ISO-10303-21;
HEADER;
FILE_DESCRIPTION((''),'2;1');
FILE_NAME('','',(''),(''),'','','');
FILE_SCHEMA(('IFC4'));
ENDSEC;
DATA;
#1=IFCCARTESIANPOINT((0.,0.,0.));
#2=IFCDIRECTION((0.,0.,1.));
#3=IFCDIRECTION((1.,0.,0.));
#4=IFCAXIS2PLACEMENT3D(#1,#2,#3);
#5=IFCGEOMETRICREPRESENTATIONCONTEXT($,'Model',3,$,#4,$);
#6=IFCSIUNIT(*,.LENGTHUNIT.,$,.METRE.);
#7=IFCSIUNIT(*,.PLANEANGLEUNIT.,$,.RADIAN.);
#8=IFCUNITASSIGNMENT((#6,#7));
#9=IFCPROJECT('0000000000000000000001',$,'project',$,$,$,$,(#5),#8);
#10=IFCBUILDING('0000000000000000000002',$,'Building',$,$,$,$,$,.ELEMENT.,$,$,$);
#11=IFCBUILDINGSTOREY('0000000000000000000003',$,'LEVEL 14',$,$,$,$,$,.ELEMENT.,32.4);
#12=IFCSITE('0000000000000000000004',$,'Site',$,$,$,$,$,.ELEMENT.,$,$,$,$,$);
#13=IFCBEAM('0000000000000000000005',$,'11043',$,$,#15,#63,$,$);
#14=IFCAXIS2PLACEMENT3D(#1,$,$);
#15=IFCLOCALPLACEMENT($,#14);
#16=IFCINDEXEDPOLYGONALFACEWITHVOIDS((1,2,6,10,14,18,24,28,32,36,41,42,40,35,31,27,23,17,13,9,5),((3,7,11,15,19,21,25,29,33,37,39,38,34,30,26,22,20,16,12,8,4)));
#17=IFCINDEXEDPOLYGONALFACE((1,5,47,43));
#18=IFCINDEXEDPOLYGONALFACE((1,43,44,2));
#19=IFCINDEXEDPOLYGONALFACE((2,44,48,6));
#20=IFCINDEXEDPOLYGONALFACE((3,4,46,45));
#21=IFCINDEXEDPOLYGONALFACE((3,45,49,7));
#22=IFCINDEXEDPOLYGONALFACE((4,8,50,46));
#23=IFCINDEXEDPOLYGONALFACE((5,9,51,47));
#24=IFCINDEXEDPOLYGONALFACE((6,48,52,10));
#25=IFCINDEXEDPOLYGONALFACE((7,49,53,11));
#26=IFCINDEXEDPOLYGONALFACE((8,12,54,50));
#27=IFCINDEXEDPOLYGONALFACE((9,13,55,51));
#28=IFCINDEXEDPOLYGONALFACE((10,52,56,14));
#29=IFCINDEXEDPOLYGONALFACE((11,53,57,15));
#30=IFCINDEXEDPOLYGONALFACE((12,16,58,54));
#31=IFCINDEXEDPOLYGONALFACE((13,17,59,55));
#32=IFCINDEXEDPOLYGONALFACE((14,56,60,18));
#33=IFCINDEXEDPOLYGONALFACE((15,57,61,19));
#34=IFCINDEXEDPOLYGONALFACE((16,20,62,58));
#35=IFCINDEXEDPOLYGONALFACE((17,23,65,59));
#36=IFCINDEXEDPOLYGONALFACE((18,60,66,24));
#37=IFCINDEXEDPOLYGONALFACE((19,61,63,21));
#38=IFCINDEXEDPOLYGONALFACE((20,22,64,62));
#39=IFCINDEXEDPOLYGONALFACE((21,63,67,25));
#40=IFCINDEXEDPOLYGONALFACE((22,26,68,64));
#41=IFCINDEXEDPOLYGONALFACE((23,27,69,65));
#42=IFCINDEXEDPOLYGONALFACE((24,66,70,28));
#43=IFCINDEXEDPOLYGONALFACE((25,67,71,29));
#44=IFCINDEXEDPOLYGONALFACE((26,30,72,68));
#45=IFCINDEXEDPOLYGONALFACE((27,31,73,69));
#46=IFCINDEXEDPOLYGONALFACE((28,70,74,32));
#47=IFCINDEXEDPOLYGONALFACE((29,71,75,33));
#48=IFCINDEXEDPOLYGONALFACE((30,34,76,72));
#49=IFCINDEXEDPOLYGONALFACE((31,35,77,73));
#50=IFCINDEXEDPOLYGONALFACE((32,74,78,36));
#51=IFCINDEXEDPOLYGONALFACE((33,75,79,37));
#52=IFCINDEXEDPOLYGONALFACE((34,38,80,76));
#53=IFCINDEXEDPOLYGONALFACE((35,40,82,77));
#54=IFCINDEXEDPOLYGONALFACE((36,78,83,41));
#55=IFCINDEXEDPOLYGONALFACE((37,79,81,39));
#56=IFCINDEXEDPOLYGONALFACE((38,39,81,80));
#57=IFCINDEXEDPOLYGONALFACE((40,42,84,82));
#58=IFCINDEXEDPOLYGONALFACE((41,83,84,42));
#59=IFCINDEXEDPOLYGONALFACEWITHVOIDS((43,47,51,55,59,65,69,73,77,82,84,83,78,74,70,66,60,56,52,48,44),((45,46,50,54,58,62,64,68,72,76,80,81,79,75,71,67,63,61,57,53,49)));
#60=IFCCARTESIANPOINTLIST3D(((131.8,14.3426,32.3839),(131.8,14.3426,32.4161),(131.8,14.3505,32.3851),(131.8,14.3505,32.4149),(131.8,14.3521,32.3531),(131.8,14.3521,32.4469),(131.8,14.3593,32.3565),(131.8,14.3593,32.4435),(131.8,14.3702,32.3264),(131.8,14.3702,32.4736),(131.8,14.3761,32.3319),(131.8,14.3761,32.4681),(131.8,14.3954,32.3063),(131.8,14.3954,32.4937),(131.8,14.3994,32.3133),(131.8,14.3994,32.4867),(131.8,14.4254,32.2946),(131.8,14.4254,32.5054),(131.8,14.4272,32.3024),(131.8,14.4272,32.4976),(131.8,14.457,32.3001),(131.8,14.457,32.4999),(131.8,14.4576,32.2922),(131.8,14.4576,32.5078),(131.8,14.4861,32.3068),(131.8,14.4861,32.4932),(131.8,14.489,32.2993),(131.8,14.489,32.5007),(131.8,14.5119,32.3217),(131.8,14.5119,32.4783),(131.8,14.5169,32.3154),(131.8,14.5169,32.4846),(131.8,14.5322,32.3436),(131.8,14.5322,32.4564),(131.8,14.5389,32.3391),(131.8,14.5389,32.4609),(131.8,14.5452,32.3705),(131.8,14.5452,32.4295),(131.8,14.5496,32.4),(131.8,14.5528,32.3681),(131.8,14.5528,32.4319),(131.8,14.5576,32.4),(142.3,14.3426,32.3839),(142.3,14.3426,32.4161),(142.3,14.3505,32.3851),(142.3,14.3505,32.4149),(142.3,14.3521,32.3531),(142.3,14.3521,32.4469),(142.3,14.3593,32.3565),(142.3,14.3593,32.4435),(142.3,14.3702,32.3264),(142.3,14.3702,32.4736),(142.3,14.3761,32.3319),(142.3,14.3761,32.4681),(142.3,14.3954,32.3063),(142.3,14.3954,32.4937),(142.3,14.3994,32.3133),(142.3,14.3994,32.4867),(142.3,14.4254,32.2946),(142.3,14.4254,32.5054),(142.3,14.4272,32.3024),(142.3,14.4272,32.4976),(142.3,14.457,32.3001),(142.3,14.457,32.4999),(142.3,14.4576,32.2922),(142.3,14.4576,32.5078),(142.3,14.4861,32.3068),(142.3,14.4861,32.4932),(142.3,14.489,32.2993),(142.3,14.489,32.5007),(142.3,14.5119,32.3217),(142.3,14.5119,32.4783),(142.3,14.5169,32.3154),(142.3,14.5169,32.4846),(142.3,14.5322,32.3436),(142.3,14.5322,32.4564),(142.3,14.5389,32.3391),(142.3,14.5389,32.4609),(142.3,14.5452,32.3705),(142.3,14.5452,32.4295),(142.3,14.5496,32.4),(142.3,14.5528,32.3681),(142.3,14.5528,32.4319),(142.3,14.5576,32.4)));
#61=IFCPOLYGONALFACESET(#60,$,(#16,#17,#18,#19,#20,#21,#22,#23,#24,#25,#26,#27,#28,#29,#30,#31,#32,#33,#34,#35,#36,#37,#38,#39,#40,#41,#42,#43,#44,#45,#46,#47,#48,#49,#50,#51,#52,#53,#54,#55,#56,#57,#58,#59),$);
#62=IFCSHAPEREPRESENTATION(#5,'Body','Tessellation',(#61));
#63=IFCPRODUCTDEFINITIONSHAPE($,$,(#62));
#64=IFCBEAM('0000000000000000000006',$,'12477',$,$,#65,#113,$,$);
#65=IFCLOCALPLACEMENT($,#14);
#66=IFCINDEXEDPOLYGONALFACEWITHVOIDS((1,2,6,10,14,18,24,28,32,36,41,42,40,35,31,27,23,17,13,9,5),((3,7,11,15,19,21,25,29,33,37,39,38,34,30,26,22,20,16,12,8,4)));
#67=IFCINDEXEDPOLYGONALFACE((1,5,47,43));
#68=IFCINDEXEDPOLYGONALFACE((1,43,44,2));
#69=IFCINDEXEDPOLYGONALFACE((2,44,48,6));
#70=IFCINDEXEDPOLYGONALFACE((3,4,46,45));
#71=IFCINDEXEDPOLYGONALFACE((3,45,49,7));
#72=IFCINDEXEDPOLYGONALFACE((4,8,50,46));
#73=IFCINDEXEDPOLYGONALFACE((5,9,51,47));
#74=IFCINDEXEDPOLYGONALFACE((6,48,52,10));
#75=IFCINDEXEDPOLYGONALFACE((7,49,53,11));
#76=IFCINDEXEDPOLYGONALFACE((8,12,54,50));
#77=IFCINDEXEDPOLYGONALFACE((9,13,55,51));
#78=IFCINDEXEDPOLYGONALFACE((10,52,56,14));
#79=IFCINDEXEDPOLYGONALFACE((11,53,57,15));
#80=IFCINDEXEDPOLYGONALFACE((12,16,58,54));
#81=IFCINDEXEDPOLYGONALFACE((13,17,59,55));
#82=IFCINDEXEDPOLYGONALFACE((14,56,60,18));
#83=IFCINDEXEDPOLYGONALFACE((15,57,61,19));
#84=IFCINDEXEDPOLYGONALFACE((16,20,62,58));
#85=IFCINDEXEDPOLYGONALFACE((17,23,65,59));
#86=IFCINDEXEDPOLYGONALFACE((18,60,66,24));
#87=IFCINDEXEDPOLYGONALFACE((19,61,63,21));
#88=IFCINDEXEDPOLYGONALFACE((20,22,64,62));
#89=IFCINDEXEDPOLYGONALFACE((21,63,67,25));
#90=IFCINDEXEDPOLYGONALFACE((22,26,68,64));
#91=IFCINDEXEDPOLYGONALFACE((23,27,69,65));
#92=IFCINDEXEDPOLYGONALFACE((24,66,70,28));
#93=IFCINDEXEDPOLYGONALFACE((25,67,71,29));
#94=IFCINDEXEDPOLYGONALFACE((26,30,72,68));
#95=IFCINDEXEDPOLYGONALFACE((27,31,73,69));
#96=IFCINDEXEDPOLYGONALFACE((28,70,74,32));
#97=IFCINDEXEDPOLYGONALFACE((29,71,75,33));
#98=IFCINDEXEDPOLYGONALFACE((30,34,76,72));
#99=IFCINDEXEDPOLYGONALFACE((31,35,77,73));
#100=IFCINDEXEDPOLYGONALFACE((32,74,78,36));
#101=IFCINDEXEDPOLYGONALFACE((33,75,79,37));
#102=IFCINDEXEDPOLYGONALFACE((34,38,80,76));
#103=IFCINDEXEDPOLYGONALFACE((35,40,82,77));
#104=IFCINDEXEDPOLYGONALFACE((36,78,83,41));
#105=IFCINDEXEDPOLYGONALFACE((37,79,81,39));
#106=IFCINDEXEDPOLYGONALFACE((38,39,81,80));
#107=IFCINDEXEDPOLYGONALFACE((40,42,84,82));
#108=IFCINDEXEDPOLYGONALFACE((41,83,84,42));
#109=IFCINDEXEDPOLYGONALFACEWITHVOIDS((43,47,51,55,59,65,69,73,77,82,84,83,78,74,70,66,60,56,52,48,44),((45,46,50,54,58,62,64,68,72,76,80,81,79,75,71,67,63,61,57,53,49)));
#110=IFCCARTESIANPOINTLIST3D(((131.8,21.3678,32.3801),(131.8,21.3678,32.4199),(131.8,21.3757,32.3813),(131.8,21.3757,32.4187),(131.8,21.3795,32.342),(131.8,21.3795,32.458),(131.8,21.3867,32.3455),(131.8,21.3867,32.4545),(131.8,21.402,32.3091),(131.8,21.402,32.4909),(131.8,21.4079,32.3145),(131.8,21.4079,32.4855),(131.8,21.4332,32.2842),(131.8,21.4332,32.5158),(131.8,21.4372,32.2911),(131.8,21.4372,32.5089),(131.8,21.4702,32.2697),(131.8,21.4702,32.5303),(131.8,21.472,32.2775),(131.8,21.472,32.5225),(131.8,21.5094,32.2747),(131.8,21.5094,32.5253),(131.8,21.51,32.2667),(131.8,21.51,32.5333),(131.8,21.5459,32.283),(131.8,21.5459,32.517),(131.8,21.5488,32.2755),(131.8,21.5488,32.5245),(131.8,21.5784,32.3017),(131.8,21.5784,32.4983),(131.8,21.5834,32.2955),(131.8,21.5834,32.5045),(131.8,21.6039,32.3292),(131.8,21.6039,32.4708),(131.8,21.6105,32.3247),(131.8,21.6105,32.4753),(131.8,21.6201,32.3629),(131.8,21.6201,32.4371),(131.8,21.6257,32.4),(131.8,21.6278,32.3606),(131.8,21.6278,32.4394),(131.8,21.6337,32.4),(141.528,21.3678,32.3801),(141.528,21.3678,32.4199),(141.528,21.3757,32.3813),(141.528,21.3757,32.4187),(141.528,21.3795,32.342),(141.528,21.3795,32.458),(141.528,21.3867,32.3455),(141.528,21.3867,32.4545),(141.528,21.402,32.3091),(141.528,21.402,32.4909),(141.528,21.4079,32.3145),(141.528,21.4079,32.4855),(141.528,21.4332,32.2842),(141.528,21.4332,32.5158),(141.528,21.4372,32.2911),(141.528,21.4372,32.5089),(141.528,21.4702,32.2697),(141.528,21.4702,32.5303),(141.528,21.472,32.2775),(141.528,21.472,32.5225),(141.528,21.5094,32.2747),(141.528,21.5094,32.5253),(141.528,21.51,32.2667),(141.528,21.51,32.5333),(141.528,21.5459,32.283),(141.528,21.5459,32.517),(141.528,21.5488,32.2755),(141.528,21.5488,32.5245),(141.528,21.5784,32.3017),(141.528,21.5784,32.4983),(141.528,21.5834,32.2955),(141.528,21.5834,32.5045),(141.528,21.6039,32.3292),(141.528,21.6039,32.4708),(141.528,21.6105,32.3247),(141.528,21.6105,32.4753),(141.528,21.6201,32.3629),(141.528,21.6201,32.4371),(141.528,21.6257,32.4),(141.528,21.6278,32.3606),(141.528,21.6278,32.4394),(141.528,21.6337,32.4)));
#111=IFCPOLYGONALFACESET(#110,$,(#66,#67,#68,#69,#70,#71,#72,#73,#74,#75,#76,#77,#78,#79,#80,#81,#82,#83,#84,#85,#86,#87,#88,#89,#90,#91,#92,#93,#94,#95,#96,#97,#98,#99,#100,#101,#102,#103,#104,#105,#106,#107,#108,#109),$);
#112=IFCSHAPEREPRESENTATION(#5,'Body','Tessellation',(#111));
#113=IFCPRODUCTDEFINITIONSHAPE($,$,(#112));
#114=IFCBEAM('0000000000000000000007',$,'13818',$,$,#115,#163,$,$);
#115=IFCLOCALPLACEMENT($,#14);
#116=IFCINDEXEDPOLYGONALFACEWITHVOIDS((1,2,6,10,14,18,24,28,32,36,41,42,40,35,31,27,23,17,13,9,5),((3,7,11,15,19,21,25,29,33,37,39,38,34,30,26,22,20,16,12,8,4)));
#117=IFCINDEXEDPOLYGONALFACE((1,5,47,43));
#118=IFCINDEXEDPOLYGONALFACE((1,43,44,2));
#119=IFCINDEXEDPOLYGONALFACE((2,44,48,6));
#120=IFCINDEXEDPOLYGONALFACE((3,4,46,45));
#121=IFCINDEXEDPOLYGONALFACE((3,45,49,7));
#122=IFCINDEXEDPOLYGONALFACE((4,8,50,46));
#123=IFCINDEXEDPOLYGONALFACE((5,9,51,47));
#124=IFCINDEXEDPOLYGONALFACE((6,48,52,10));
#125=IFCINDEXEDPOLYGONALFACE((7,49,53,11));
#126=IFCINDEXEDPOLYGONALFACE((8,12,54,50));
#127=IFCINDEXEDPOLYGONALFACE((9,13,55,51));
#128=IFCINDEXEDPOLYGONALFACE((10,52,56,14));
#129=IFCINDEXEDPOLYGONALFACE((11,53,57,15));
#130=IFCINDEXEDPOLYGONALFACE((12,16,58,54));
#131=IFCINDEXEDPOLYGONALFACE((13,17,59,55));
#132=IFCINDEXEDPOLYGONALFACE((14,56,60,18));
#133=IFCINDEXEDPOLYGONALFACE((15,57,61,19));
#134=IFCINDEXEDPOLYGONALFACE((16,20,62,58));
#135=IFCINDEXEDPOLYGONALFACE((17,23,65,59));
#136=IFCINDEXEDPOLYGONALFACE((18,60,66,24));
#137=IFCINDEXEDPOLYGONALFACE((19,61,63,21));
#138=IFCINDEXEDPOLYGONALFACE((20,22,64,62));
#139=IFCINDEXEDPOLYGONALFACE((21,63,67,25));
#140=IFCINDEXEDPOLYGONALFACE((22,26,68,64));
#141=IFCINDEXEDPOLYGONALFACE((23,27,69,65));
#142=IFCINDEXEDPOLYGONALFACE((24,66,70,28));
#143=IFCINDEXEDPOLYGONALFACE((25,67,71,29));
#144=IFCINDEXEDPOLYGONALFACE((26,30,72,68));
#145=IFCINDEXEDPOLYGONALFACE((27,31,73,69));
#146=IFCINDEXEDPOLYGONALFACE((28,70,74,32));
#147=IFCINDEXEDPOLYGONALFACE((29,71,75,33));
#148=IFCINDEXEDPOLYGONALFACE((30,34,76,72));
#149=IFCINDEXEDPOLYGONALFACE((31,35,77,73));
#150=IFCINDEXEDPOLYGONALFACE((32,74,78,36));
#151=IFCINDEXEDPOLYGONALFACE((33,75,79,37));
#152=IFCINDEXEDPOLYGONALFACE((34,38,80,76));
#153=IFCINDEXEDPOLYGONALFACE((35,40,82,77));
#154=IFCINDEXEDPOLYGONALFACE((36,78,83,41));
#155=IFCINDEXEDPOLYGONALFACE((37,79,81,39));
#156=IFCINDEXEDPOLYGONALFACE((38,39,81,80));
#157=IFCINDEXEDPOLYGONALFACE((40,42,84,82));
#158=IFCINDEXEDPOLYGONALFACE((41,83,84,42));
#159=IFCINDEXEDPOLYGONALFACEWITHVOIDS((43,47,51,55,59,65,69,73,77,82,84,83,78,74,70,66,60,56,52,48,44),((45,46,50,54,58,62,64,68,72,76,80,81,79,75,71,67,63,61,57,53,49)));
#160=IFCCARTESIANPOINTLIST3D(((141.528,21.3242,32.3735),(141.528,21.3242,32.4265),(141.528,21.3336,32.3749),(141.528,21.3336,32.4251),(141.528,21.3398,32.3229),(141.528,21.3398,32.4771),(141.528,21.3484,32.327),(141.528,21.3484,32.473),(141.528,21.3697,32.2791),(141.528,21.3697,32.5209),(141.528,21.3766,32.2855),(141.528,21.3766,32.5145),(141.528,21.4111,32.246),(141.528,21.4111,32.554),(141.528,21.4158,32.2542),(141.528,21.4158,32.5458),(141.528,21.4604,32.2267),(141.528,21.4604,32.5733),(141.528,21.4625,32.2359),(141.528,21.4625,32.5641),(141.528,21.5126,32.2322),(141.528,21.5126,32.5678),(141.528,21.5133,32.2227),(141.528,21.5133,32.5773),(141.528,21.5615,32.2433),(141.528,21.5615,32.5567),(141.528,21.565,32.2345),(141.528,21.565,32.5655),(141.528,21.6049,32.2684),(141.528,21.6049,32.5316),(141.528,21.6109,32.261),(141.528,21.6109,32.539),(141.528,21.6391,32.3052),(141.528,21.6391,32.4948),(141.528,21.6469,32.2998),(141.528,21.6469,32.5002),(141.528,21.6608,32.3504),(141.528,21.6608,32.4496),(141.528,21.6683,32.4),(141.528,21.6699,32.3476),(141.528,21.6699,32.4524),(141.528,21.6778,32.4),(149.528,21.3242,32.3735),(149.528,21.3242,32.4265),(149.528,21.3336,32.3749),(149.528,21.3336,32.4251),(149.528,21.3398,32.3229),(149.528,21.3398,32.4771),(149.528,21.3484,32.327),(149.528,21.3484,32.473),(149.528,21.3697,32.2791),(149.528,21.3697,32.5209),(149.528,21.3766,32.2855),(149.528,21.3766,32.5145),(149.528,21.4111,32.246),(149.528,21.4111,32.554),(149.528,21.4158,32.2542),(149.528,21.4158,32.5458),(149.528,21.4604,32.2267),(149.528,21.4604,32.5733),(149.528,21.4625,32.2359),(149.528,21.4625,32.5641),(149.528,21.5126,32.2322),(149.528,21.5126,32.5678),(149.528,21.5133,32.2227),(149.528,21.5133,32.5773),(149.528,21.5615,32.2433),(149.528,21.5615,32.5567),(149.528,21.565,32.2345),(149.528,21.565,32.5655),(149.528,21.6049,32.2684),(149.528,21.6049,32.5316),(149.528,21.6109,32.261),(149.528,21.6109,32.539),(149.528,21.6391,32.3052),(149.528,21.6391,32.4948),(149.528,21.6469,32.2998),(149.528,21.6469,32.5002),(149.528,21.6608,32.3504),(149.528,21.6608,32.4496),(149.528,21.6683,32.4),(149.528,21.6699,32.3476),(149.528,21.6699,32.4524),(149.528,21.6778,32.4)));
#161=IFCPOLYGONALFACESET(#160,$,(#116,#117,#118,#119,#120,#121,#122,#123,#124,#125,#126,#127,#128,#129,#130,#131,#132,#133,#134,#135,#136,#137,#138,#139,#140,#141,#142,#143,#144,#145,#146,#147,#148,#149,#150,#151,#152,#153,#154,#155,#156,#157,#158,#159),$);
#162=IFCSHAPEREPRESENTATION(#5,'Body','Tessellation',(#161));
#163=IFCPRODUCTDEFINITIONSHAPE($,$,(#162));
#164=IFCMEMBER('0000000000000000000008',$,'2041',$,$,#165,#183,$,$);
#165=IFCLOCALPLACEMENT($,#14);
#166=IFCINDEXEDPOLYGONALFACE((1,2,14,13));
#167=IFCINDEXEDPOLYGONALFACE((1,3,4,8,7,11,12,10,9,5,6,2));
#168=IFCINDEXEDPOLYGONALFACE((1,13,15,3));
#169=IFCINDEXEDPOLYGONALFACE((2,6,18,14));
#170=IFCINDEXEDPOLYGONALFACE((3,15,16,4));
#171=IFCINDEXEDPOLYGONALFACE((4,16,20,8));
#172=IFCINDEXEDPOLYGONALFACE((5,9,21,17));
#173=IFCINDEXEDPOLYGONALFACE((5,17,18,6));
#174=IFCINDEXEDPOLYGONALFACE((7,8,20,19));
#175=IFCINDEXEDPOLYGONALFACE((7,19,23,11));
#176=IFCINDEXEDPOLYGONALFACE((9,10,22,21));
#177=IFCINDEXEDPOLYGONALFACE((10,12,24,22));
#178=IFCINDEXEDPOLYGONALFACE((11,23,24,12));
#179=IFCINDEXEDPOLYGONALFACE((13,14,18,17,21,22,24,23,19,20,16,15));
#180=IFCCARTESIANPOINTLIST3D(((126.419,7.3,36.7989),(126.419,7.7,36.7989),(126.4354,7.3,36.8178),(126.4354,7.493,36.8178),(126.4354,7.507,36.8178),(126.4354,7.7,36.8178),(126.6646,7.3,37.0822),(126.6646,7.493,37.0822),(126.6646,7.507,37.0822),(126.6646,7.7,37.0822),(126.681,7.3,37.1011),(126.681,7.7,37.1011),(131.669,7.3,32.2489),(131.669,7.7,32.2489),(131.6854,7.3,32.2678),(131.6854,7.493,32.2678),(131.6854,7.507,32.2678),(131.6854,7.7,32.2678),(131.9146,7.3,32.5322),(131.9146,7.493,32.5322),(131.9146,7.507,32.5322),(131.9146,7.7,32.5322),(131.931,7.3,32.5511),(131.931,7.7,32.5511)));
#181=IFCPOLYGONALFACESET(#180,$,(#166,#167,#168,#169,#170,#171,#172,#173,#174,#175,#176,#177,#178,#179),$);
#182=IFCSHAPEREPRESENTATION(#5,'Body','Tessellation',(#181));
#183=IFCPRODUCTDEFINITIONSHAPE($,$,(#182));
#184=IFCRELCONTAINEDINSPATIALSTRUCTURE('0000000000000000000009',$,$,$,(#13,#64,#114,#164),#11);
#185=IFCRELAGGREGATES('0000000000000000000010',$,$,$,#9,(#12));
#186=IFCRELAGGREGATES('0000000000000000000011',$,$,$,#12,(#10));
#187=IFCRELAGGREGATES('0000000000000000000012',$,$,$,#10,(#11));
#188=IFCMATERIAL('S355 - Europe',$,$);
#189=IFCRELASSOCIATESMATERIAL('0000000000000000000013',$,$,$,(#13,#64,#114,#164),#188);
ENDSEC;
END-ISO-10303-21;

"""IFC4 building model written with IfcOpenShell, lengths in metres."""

from ifc_helpers import new_model, si_unit, frame, origin_with_axes, origin_2d_with_axis, place, context, project, spatial, hollow_circle, i_section, extrude, material, material_profile, profile_set, profile_usage, element, save


model = new_model("IFC4")

# Units and contexts
model_context = context("Model", 3, world=origin_with_axes())
ifc_project = project(units=[si_unit("LENGTHUNIT", "METRE"), si_unit("PLANEANGLEUNIT", "RADIAN")], contexts=[model_context])

# Site, building, storey
site = spatial("IfcSite", under=ifc_project, Name="Site", CompositionType="ELEMENT")
building = spatial("IfcBuilding", under=site, Name="Building", CompositionType="ELEMENT")
storey = spatial("IfcBuildingStorey", under=building, Name="LEVEL 14", CompositionType="ELEMENT", Elevation=32.4)

# Shared definitions
ifc_material = material(Name="S355 - Europe")

# Beams
ifc_material_profile_1 = material_profile(ifc_material, hollow_circle(Radius=0.1081, WallThickness=0.008, at=origin_2d_with_axis()))
ifc_profile_set_1 = profile_set([ifc_material_profile_1])
ifc_profile_usage_1 = profile_usage(ifc_profile_set_1, cardinal=10)
beam_1_placement = place(None, frame((131.8, 14.4495, 32.4), z_axis=(1.0, 0.0, 0.0), x_axis=(0.0, 1.0, 0.0)))
element("IfcBeam", 1, at=beam_1_placement, inside=storey, material=ifc_profile_usage_1, Name="11043", context=model_context, shape_type="SweptSolid", body=[
    extrude(hollow_circle(Radius=0.1081, WallThickness=0.008, at=origin_2d_with_axis()), origin_with_axes(), (0.0, 0.0, 1.0), 10.5),
])
ifc_material_profile_2 = material_profile(ifc_material, hollow_circle(Radius=0.1337, WallThickness=0.008, at=origin_2d_with_axis()))
ifc_profile_set_2 = profile_set([ifc_material_profile_2])
ifc_profile_usage_2 = profile_usage(ifc_profile_set_2, cardinal=10)
beam_2_placement = place(None, frame((131.8, 21.5, 32.4), z_axis=(1.0, 0.0, 0.0), x_axis=(0.0, 1.0, 0.0)))
element("IfcBeam", 2, at=beam_2_placement, inside=storey, material=ifc_profile_usage_2, Name="12477", context=model_context, shape_type="SweptSolid", body=[
    extrude(hollow_circle(Radius=0.1337, WallThickness=0.008, at=origin_2d_with_axis()), origin_with_axes(), (0.0, 0.0, 1.0), 9.728),
])
ifc_material_profile_3 = material_profile(ifc_material, hollow_circle(Radius=0.1778, WallThickness=0.0095, at=origin_2d_with_axis()))
ifc_profile_set_3 = profile_set([ifc_material_profile_3])
ifc_profile_usage_3 = profile_usage(ifc_profile_set_3, cardinal=10)
beam_3_placement = place(None, frame((141.528, 21.5, 32.4), z_axis=(1.0, 0.0, 0.0), x_axis=(0.0, 1.0, 0.0)))
element("IfcBeam", 3, at=beam_3_placement, inside=storey, material=ifc_profile_usage_3, Name="13818", context=model_context, shape_type="SweptSolid", body=[
    extrude(hollow_circle(Radius=0.1778, WallThickness=0.0095, at=origin_2d_with_axis()), origin_with_axes(), (0.0, 0.0, 1.0), 8.0),
])

# Member
ifc_material_profile_4 = material_profile(ifc_material, i_section(OverallWidth=0.4, OverallDepth=0.4, WebThickness=0.014, FlangeThickness=0.025, at=origin_2d_with_axis()))
ifc_profile_set_4 = profile_set([ifc_material_profile_4])
ifc_profile_usage_4 = profile_usage(ifc_profile_set_4, cardinal=10)
member_1_placement = place(None, frame((131.8, 7.5, 32.4), z_axis=(-0.755689, 0.0, 0.654931), x_axis=(0.0, -1.0, 0.0)))
element("IfcMember", 4, at=member_1_placement, inside=storey, material=ifc_profile_usage_4, Name="2041", context=model_context, shape_type="SweptSolid", body=[
    extrude(i_section(OverallWidth=0.4, OverallDepth=0.4, WebThickness=0.014, FlangeThickness=0.025, at=origin_2d_with_axis()), origin_with_axes(), (0.0, 0.0, 1.0), 6.9473),
])

save(model, "model.ifc")
